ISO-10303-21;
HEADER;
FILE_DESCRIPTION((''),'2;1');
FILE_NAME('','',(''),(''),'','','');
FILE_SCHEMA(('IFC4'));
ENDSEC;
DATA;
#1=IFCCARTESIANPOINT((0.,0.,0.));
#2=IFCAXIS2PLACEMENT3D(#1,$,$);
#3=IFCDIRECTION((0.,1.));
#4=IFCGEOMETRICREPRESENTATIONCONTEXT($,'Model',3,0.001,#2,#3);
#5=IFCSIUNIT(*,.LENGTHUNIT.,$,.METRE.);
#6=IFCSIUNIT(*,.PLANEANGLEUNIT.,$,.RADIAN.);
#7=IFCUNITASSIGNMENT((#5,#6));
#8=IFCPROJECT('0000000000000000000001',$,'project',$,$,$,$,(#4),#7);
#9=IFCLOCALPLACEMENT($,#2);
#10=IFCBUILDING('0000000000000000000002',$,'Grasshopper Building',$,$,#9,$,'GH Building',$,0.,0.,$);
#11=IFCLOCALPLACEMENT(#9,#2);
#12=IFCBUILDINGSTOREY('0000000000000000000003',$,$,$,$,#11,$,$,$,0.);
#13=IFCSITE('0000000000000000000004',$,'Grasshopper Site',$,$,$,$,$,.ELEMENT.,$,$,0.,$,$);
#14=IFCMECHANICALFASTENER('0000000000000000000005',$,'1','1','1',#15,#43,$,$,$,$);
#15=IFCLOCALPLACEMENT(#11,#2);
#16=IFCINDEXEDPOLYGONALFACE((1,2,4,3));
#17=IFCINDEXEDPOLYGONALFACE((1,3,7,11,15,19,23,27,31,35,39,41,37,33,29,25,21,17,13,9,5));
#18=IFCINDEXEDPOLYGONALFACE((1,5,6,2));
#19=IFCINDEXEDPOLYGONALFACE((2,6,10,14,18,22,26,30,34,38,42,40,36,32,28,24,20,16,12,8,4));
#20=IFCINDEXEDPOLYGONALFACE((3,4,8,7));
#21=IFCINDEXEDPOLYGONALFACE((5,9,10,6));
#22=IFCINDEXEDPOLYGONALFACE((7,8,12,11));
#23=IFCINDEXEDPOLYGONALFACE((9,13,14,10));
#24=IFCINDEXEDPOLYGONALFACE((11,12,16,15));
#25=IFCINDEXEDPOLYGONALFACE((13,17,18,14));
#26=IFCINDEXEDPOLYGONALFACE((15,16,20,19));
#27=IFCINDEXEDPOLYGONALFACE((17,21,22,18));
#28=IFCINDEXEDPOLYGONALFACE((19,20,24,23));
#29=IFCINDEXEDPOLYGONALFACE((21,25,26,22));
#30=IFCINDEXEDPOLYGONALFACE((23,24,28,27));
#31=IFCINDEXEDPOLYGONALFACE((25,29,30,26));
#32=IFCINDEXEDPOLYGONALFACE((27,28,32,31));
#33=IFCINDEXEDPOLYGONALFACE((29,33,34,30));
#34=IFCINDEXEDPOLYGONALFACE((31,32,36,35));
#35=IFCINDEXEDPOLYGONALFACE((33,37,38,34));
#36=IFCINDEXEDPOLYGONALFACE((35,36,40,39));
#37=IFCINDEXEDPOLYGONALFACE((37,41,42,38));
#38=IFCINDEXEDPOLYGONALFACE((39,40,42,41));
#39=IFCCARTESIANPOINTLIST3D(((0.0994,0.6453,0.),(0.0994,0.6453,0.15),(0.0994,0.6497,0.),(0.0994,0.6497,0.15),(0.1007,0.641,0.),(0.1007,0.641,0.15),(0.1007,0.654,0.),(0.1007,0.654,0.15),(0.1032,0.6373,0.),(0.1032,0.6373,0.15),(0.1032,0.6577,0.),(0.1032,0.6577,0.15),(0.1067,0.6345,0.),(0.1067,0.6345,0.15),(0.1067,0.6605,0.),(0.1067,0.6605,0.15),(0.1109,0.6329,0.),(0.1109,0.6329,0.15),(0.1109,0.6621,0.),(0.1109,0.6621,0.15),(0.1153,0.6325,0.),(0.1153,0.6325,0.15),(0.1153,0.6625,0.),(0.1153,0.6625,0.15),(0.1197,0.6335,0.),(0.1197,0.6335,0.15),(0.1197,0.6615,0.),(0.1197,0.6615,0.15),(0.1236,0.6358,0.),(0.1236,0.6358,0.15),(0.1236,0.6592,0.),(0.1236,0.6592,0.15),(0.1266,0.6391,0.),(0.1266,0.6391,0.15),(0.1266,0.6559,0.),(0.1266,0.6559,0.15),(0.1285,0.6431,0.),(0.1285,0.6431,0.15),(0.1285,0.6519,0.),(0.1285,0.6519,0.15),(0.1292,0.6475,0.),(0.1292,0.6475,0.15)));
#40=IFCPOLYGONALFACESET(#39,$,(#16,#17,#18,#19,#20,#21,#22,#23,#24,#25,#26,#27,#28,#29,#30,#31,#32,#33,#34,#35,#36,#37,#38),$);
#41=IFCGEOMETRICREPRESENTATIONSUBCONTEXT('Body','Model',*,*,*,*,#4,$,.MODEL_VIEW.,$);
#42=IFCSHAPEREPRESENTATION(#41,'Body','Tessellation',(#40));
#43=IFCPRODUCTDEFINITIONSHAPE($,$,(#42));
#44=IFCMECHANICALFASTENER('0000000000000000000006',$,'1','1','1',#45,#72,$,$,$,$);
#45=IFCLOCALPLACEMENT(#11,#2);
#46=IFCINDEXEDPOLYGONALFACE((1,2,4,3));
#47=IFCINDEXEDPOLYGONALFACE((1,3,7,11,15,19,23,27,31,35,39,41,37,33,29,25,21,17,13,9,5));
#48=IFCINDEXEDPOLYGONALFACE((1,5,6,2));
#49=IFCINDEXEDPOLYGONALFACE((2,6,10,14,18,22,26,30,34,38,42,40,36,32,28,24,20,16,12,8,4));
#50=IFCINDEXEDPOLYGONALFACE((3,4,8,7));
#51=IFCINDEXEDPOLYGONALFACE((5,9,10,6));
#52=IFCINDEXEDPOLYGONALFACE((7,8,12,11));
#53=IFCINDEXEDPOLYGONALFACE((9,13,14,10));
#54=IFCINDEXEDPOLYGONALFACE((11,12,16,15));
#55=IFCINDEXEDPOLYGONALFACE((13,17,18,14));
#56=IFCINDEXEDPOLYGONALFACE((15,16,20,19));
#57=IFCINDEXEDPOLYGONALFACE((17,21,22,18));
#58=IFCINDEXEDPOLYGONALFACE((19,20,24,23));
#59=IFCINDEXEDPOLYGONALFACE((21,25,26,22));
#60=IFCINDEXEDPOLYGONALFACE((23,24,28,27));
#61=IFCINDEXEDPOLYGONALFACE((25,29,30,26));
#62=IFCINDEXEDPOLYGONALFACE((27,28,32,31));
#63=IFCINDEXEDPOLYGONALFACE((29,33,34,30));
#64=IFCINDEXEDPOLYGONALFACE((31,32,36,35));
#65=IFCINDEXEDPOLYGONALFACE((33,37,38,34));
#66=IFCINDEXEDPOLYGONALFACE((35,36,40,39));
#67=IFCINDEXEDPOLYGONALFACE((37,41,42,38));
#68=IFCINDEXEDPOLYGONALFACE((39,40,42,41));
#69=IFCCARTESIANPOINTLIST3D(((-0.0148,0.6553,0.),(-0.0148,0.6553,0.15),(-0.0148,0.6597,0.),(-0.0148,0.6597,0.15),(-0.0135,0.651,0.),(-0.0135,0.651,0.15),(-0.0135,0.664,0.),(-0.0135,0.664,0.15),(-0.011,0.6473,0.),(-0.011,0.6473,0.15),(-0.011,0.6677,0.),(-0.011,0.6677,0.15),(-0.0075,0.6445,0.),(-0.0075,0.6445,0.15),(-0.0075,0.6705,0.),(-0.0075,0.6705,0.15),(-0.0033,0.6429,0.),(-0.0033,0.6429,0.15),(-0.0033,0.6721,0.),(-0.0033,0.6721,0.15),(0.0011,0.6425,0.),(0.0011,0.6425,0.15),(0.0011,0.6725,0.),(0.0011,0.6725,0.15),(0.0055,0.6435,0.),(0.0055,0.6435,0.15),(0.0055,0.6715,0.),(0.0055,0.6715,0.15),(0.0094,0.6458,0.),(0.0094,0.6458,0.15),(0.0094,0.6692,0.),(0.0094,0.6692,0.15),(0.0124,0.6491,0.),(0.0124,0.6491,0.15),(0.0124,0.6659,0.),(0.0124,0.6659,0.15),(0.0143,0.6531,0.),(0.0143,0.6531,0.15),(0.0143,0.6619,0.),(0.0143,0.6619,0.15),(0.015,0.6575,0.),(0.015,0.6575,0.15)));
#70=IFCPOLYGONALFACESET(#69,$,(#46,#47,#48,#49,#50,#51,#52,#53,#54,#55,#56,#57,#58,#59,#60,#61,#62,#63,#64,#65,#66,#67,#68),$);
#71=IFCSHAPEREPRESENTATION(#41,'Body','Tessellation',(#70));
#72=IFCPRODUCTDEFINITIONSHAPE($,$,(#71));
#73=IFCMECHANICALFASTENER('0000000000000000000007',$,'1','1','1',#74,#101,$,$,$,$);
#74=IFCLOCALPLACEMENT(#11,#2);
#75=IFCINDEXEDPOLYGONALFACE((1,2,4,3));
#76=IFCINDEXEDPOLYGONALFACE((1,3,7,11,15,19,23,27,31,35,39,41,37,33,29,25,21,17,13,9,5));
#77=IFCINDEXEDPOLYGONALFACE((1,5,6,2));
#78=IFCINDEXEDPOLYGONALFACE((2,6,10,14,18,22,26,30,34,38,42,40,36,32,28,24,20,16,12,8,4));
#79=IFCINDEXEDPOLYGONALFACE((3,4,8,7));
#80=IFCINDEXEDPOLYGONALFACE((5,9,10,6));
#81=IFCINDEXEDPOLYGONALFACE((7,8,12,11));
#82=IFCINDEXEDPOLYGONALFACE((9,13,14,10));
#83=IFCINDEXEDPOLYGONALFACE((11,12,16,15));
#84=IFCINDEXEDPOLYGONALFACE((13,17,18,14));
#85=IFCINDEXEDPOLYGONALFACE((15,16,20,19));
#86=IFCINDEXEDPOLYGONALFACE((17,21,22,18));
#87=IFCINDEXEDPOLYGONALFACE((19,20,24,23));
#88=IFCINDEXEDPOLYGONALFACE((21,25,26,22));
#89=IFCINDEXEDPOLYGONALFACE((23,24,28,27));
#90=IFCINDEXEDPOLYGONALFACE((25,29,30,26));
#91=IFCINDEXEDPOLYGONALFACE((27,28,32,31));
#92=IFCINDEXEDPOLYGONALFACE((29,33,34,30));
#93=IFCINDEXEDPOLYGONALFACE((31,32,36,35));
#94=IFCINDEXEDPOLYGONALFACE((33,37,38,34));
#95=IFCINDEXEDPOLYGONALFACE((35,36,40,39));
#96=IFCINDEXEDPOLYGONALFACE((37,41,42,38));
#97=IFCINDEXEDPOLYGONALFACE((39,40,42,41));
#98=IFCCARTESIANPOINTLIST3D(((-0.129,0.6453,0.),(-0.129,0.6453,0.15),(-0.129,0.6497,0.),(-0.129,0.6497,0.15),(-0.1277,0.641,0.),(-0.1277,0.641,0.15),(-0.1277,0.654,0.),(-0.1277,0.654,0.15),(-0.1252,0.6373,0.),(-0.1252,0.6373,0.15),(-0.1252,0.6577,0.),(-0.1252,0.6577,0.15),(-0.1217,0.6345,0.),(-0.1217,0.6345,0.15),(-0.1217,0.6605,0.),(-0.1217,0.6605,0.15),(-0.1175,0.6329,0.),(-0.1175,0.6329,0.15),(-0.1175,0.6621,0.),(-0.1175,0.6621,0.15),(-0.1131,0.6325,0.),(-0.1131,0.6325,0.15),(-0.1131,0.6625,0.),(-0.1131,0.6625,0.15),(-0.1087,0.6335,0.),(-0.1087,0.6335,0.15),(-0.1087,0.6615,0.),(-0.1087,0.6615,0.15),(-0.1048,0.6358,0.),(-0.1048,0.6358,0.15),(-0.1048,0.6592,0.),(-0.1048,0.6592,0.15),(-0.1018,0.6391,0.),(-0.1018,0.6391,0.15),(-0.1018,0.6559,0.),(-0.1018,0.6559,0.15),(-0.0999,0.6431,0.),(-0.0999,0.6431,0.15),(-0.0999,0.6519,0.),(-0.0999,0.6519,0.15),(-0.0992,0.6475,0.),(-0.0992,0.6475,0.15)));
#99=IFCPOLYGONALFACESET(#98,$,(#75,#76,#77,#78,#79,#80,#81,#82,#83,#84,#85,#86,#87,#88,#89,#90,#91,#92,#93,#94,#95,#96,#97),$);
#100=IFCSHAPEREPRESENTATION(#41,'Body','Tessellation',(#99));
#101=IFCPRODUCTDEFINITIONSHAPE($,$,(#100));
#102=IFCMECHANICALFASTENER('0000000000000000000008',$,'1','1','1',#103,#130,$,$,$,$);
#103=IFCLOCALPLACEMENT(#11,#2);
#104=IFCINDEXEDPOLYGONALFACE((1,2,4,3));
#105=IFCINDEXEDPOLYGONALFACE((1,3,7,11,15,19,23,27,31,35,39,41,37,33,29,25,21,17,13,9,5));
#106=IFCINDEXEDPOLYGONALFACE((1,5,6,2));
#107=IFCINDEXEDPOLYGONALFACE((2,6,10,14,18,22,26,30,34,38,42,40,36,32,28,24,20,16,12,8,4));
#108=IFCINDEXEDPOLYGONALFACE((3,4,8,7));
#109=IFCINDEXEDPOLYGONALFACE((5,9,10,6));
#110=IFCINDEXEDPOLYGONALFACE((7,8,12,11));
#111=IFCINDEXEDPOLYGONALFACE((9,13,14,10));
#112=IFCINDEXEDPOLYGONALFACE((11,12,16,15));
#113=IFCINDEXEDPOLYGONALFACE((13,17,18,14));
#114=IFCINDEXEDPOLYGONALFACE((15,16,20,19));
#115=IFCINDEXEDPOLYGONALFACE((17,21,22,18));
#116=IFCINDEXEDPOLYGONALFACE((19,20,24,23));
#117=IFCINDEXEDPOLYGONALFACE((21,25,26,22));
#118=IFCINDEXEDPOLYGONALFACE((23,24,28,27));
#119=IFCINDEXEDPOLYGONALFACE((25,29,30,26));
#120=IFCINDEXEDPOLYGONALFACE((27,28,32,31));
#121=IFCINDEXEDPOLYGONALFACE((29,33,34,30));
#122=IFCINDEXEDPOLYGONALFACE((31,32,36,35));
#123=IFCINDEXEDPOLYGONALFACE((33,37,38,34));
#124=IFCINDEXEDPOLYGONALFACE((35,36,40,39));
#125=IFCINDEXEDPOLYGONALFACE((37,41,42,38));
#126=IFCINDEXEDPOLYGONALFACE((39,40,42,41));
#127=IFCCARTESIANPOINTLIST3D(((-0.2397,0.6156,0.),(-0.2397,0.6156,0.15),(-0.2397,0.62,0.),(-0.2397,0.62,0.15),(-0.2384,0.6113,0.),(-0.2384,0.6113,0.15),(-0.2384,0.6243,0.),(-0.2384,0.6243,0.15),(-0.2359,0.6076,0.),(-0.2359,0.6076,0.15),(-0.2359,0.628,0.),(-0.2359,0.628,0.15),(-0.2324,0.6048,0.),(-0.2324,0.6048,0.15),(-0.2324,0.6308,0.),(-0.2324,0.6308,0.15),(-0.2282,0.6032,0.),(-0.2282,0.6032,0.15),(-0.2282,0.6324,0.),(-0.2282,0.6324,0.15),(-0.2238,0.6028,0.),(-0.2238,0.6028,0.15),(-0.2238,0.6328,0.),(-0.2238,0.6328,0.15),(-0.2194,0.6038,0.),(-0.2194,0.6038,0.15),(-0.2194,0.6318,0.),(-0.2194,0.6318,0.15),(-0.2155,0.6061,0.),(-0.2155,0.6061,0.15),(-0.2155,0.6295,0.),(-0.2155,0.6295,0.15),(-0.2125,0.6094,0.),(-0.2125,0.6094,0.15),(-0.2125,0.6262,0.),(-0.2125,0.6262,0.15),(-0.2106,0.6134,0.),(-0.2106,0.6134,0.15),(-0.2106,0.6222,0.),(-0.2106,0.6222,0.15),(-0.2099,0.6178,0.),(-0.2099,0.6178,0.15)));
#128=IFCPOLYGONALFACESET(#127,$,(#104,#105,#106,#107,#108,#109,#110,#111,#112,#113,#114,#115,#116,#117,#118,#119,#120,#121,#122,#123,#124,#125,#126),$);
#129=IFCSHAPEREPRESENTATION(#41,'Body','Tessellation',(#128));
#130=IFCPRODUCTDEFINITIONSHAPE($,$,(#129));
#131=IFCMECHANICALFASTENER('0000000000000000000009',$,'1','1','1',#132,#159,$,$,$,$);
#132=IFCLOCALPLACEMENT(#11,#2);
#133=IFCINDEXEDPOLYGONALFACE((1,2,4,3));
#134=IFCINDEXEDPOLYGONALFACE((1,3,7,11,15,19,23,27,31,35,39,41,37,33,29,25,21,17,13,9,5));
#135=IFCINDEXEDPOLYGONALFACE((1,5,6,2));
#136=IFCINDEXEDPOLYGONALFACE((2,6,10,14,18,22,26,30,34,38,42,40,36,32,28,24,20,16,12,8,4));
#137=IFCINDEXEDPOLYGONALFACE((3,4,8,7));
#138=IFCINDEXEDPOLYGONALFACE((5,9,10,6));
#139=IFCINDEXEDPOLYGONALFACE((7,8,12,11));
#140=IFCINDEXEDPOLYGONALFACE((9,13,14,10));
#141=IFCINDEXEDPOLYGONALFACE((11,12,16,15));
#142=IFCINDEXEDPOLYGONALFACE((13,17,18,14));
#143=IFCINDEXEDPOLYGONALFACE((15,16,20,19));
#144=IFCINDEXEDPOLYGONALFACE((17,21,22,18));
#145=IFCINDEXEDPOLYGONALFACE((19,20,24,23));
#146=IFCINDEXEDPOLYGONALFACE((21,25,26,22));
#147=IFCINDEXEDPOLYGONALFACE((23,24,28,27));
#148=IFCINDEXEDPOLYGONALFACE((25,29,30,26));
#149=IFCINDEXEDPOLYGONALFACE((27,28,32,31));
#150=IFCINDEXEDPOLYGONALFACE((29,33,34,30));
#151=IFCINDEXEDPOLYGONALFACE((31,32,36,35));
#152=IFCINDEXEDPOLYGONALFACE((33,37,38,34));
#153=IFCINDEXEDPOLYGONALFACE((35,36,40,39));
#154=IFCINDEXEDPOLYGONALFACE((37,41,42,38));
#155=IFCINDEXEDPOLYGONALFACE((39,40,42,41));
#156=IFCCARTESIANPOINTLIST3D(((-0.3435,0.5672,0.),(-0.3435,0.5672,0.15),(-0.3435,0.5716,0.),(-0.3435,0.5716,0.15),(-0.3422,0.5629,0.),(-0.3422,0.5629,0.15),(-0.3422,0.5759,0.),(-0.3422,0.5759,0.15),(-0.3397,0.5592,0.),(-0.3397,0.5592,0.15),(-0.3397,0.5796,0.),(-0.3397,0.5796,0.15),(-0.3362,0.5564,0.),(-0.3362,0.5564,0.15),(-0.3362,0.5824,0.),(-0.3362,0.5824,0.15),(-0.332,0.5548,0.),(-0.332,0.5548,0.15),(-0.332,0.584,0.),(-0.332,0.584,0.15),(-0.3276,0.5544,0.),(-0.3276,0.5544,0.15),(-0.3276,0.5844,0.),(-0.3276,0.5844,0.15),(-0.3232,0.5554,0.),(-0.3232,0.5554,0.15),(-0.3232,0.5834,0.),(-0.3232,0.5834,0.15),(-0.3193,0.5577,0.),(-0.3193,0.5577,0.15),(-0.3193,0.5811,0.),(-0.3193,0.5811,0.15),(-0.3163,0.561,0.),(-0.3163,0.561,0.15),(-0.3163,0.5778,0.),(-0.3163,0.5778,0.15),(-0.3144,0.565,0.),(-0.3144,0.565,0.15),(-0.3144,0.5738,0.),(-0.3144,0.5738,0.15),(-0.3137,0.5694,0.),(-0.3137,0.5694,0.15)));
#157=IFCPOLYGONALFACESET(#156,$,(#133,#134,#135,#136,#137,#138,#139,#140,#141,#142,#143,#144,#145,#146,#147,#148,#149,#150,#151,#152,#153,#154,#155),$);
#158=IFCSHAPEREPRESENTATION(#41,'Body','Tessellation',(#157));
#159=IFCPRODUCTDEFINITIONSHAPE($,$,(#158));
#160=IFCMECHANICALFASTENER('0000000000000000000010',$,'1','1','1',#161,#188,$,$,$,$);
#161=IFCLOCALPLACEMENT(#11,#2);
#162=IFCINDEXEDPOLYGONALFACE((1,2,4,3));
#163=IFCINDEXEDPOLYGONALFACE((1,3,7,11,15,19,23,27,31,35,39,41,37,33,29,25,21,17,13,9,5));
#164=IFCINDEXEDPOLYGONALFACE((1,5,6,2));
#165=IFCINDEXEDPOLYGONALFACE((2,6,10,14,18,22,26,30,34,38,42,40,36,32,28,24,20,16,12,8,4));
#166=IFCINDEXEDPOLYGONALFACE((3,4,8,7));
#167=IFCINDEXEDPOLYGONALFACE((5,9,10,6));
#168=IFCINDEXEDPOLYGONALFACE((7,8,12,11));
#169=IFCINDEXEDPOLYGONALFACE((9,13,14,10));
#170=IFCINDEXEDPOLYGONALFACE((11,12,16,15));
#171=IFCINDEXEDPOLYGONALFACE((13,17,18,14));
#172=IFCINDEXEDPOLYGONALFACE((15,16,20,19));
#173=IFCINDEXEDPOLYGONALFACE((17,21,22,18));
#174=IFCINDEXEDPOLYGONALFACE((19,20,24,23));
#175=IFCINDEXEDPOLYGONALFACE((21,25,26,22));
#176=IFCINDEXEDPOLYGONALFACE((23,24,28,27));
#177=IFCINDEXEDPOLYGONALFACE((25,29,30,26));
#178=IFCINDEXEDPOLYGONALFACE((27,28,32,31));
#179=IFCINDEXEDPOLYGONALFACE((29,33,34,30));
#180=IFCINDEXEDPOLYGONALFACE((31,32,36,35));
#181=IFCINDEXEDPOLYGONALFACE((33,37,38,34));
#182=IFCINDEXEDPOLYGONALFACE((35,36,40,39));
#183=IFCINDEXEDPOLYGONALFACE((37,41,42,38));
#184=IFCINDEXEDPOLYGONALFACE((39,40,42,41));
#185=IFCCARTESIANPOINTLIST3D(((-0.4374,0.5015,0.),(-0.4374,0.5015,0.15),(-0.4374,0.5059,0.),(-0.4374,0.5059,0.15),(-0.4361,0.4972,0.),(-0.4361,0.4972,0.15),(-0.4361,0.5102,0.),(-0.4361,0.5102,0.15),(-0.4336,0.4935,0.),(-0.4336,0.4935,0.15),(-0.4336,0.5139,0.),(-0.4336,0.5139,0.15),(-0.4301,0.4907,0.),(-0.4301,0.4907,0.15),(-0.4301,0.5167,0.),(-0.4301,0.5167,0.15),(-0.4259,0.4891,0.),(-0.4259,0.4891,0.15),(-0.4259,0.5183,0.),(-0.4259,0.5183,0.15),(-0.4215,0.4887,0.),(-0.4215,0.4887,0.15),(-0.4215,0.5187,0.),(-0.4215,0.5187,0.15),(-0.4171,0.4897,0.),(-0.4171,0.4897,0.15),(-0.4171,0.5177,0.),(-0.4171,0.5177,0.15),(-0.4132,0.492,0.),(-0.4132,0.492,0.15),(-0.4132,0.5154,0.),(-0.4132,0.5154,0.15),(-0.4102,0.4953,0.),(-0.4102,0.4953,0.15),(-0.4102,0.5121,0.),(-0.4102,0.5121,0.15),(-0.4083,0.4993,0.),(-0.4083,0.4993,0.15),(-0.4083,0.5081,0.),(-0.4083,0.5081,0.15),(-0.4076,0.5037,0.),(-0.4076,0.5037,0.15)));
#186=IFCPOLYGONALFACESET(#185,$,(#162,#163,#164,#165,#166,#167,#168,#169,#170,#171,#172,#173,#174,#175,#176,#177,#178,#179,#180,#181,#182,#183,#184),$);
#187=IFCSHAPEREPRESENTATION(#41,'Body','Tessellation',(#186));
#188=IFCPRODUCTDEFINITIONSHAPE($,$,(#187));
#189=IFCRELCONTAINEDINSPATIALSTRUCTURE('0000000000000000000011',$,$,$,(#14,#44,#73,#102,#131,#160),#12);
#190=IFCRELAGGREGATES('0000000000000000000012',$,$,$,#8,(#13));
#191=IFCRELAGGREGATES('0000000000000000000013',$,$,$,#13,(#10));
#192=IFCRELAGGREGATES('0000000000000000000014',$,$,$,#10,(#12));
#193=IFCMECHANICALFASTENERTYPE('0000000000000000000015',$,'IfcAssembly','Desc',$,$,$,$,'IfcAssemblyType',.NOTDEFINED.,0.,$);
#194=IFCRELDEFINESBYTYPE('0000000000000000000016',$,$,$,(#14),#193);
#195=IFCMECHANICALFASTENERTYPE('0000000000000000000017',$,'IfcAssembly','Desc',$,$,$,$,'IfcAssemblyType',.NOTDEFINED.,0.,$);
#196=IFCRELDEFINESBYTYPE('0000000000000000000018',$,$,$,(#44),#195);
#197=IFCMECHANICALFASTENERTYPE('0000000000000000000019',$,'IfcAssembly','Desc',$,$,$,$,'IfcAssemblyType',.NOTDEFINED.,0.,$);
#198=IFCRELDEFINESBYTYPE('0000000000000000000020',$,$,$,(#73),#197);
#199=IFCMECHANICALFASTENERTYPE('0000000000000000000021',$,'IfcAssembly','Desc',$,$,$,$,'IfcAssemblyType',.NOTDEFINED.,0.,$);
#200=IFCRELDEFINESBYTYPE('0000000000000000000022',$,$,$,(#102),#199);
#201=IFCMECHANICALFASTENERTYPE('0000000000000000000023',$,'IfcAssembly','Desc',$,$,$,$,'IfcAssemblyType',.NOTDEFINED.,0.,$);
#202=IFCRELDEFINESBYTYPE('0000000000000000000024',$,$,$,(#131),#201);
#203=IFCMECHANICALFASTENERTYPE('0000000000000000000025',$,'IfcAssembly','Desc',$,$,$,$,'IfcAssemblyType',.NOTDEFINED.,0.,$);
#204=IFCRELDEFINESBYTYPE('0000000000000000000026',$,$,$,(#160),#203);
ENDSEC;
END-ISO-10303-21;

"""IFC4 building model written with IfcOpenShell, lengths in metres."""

from ifc_helpers import new_model, si_unit, direction, frame, origin, place, context, subcontext, project, spatial, circle, extrude, source, transform, mapped, type_object, type_shapes, element, save


model = new_model("IFC4")

# Units and contexts
model_context = context("Model", 3, precision=0.001, world=origin(), true_north=direction((0.0, 1.0)))
body_context = subcontext(model_context, "Body", "Model", "MODEL_VIEW")
ifc_project = project(units=[si_unit("LENGTHUNIT", "METRE"), si_unit("PLANEANGLEUNIT", "RADIAN")], contexts=[model_context])

# Site, building, storey
site = spatial("IfcSite", under=ifc_project, Name="Grasshopper Site", CompositionType="ELEMENT", RefElevation=0.0)
building_placement = place(None, origin())
building = spatial("IfcBuilding", under=site, at=building_placement, Name="Grasshopper Building", LongName="GH Building", ElevationOfRefHeight=0.0, ElevationOfTerrain=0.0)
storey_placement = place(building_placement, origin())
storey = spatial("IfcBuildingStorey", under=building, at=storey_placement, Elevation=0.0)

# Mechanical fasteners
mechanical_fastener_type_1 = type_object("IfcMechanicalFastenerType", Name="IfcAssembly", Description="Desc", ElementType="IfcAssemblyType", NominalDiameter=0.0)
shared_shape_1 = source(origin(), body_context, "Body", "SweptSolid", [
    extrude(circle(Radius=0.015), frame((0.1142, 0.6475, 0.0)), (0.0, 0.0, 1.0), 0.15),
])
type_shapes(mechanical_fastener_type_1, [shared_shape_1])
mechanical_fastener_1_placement = place(storey_placement, origin())
element("IfcMechanicalFastener", 1, at=mechanical_fastener_1_placement, inside=storey, type_object=mechanical_fastener_type_1, Name="1", Description="1", ObjectType="1", context=body_context, shape_type="MappedRepresentation", body=[
    mapped(shared_shape_1, transform((0.0, 0.0, 0.0), scale=1.0)),
])
mechanical_fastener_type_2 = type_object("IfcMechanicalFastenerType", Name="IfcAssembly", Description="Desc", ElementType="IfcAssemblyType", NominalDiameter=0.0)
shared_shape_2 = source(origin(), body_context, "Body", "SweptSolid", [
    extrude(circle(Radius=0.015), frame((0.0, 0.6575, 0.0)), (0.0, 0.0, 1.0), 0.15),
])
type_shapes(mechanical_fastener_type_2, [shared_shape_2])
mechanical_fastener_2_placement = place(storey_placement, origin())
element("IfcMechanicalFastener", 2, at=mechanical_fastener_2_placement, inside=storey, type_object=mechanical_fastener_type_2, Name="1", Description="1", ObjectType="1", context=body_context, shape_type="MappedRepresentation", body=[
    mapped(shared_shape_2, transform((0.0, 0.0, 0.0), scale=1.0)),
])
mechanical_fastener_type_3 = type_object("IfcMechanicalFastenerType", Name="IfcAssembly", Description="Desc", ElementType="IfcAssemblyType", NominalDiameter=0.0)
shared_shape_3 = source(origin(), body_context, "Body", "SweptSolid", [
    extrude(circle(Radius=0.015), frame((-0.1142, 0.6475, 0.0)), (0.0, 0.0, 1.0), 0.15),
])
type_shapes(mechanical_fastener_type_3, [shared_shape_3])
mechanical_fastener_3_placement = place(storey_placement, origin())
element("IfcMechanicalFastener", 3, at=mechanical_fastener_3_placement, inside=storey, type_object=mechanical_fastener_type_3, Name="1", Description="1", ObjectType="1", context=body_context, shape_type="MappedRepresentation", body=[
    mapped(shared_shape_3, transform((0.0, 0.0, 0.0), scale=1.0)),
])
mechanical_fastener_type_4 = type_object("IfcMechanicalFastenerType", Name="IfcAssembly", Description="Desc", ElementType="IfcAssemblyType", NominalDiameter=0.0)
shared_shape_4 = source(origin(), body_context, "Body", "SweptSolid", [
    extrude(circle(Radius=0.015), frame((-0.2249, 0.6178, 0.0)), (0.0, 0.0, 1.0), 0.15),
])
type_shapes(mechanical_fastener_type_4, [shared_shape_4])
mechanical_fastener_4_placement = place(storey_placement, origin())
element("IfcMechanicalFastener", 4, at=mechanical_fastener_4_placement, inside=storey, type_object=mechanical_fastener_type_4, Name="1", Description="1", ObjectType="1", context=body_context, shape_type="MappedRepresentation", body=[
    mapped(shared_shape_4, transform((0.0, 0.0, 0.0), scale=1.0)),
])
mechanical_fastener_type_5 = type_object("IfcMechanicalFastenerType", Name="IfcAssembly", Description="Desc", ElementType="IfcAssemblyType", NominalDiameter=0.0)
shared_shape_5 = source(origin(), body_context, "Body", "SweptSolid", [
    extrude(circle(Radius=0.015), frame((-0.3287, 0.5694, 0.0)), (0.0, 0.0, 1.0), 0.15),
])
type_shapes(mechanical_fastener_type_5, [shared_shape_5])
mechanical_fastener_5_placement = place(storey_placement, origin())
element("IfcMechanicalFastener", 5, at=mechanical_fastener_5_placement, inside=storey, type_object=mechanical_fastener_type_5, Name="1", Description="1", ObjectType="1", context=body_context, shape_type="MappedRepresentation", body=[
    mapped(shared_shape_5, transform((0.0, 0.0, 0.0), scale=1.0)),
])
mechanical_fastener_type_6 = type_object("IfcMechanicalFastenerType", Name="IfcAssembly", Description="Desc", ElementType="IfcAssemblyType", NominalDiameter=0.0)
shared_shape_6 = source(origin(), body_context, "Body", "SweptSolid", [
    extrude(circle(Radius=0.015), frame((-0.4226, 0.5037, 0.0)), (0.0, 0.0, 1.0), 0.15),
])
type_shapes(mechanical_fastener_type_6, [shared_shape_6])
mechanical_fastener_6_placement = place(storey_placement, origin())
element("IfcMechanicalFastener", 6, at=mechanical_fastener_6_placement, inside=storey, type_object=mechanical_fastener_type_6, Name="1", Description="1", ObjectType="1", context=body_context, shape_type="MappedRepresentation", body=[
    mapped(shared_shape_6, transform((0.0, 0.0, 0.0), scale=1.0)),
])

save(model, "model.ifc")
